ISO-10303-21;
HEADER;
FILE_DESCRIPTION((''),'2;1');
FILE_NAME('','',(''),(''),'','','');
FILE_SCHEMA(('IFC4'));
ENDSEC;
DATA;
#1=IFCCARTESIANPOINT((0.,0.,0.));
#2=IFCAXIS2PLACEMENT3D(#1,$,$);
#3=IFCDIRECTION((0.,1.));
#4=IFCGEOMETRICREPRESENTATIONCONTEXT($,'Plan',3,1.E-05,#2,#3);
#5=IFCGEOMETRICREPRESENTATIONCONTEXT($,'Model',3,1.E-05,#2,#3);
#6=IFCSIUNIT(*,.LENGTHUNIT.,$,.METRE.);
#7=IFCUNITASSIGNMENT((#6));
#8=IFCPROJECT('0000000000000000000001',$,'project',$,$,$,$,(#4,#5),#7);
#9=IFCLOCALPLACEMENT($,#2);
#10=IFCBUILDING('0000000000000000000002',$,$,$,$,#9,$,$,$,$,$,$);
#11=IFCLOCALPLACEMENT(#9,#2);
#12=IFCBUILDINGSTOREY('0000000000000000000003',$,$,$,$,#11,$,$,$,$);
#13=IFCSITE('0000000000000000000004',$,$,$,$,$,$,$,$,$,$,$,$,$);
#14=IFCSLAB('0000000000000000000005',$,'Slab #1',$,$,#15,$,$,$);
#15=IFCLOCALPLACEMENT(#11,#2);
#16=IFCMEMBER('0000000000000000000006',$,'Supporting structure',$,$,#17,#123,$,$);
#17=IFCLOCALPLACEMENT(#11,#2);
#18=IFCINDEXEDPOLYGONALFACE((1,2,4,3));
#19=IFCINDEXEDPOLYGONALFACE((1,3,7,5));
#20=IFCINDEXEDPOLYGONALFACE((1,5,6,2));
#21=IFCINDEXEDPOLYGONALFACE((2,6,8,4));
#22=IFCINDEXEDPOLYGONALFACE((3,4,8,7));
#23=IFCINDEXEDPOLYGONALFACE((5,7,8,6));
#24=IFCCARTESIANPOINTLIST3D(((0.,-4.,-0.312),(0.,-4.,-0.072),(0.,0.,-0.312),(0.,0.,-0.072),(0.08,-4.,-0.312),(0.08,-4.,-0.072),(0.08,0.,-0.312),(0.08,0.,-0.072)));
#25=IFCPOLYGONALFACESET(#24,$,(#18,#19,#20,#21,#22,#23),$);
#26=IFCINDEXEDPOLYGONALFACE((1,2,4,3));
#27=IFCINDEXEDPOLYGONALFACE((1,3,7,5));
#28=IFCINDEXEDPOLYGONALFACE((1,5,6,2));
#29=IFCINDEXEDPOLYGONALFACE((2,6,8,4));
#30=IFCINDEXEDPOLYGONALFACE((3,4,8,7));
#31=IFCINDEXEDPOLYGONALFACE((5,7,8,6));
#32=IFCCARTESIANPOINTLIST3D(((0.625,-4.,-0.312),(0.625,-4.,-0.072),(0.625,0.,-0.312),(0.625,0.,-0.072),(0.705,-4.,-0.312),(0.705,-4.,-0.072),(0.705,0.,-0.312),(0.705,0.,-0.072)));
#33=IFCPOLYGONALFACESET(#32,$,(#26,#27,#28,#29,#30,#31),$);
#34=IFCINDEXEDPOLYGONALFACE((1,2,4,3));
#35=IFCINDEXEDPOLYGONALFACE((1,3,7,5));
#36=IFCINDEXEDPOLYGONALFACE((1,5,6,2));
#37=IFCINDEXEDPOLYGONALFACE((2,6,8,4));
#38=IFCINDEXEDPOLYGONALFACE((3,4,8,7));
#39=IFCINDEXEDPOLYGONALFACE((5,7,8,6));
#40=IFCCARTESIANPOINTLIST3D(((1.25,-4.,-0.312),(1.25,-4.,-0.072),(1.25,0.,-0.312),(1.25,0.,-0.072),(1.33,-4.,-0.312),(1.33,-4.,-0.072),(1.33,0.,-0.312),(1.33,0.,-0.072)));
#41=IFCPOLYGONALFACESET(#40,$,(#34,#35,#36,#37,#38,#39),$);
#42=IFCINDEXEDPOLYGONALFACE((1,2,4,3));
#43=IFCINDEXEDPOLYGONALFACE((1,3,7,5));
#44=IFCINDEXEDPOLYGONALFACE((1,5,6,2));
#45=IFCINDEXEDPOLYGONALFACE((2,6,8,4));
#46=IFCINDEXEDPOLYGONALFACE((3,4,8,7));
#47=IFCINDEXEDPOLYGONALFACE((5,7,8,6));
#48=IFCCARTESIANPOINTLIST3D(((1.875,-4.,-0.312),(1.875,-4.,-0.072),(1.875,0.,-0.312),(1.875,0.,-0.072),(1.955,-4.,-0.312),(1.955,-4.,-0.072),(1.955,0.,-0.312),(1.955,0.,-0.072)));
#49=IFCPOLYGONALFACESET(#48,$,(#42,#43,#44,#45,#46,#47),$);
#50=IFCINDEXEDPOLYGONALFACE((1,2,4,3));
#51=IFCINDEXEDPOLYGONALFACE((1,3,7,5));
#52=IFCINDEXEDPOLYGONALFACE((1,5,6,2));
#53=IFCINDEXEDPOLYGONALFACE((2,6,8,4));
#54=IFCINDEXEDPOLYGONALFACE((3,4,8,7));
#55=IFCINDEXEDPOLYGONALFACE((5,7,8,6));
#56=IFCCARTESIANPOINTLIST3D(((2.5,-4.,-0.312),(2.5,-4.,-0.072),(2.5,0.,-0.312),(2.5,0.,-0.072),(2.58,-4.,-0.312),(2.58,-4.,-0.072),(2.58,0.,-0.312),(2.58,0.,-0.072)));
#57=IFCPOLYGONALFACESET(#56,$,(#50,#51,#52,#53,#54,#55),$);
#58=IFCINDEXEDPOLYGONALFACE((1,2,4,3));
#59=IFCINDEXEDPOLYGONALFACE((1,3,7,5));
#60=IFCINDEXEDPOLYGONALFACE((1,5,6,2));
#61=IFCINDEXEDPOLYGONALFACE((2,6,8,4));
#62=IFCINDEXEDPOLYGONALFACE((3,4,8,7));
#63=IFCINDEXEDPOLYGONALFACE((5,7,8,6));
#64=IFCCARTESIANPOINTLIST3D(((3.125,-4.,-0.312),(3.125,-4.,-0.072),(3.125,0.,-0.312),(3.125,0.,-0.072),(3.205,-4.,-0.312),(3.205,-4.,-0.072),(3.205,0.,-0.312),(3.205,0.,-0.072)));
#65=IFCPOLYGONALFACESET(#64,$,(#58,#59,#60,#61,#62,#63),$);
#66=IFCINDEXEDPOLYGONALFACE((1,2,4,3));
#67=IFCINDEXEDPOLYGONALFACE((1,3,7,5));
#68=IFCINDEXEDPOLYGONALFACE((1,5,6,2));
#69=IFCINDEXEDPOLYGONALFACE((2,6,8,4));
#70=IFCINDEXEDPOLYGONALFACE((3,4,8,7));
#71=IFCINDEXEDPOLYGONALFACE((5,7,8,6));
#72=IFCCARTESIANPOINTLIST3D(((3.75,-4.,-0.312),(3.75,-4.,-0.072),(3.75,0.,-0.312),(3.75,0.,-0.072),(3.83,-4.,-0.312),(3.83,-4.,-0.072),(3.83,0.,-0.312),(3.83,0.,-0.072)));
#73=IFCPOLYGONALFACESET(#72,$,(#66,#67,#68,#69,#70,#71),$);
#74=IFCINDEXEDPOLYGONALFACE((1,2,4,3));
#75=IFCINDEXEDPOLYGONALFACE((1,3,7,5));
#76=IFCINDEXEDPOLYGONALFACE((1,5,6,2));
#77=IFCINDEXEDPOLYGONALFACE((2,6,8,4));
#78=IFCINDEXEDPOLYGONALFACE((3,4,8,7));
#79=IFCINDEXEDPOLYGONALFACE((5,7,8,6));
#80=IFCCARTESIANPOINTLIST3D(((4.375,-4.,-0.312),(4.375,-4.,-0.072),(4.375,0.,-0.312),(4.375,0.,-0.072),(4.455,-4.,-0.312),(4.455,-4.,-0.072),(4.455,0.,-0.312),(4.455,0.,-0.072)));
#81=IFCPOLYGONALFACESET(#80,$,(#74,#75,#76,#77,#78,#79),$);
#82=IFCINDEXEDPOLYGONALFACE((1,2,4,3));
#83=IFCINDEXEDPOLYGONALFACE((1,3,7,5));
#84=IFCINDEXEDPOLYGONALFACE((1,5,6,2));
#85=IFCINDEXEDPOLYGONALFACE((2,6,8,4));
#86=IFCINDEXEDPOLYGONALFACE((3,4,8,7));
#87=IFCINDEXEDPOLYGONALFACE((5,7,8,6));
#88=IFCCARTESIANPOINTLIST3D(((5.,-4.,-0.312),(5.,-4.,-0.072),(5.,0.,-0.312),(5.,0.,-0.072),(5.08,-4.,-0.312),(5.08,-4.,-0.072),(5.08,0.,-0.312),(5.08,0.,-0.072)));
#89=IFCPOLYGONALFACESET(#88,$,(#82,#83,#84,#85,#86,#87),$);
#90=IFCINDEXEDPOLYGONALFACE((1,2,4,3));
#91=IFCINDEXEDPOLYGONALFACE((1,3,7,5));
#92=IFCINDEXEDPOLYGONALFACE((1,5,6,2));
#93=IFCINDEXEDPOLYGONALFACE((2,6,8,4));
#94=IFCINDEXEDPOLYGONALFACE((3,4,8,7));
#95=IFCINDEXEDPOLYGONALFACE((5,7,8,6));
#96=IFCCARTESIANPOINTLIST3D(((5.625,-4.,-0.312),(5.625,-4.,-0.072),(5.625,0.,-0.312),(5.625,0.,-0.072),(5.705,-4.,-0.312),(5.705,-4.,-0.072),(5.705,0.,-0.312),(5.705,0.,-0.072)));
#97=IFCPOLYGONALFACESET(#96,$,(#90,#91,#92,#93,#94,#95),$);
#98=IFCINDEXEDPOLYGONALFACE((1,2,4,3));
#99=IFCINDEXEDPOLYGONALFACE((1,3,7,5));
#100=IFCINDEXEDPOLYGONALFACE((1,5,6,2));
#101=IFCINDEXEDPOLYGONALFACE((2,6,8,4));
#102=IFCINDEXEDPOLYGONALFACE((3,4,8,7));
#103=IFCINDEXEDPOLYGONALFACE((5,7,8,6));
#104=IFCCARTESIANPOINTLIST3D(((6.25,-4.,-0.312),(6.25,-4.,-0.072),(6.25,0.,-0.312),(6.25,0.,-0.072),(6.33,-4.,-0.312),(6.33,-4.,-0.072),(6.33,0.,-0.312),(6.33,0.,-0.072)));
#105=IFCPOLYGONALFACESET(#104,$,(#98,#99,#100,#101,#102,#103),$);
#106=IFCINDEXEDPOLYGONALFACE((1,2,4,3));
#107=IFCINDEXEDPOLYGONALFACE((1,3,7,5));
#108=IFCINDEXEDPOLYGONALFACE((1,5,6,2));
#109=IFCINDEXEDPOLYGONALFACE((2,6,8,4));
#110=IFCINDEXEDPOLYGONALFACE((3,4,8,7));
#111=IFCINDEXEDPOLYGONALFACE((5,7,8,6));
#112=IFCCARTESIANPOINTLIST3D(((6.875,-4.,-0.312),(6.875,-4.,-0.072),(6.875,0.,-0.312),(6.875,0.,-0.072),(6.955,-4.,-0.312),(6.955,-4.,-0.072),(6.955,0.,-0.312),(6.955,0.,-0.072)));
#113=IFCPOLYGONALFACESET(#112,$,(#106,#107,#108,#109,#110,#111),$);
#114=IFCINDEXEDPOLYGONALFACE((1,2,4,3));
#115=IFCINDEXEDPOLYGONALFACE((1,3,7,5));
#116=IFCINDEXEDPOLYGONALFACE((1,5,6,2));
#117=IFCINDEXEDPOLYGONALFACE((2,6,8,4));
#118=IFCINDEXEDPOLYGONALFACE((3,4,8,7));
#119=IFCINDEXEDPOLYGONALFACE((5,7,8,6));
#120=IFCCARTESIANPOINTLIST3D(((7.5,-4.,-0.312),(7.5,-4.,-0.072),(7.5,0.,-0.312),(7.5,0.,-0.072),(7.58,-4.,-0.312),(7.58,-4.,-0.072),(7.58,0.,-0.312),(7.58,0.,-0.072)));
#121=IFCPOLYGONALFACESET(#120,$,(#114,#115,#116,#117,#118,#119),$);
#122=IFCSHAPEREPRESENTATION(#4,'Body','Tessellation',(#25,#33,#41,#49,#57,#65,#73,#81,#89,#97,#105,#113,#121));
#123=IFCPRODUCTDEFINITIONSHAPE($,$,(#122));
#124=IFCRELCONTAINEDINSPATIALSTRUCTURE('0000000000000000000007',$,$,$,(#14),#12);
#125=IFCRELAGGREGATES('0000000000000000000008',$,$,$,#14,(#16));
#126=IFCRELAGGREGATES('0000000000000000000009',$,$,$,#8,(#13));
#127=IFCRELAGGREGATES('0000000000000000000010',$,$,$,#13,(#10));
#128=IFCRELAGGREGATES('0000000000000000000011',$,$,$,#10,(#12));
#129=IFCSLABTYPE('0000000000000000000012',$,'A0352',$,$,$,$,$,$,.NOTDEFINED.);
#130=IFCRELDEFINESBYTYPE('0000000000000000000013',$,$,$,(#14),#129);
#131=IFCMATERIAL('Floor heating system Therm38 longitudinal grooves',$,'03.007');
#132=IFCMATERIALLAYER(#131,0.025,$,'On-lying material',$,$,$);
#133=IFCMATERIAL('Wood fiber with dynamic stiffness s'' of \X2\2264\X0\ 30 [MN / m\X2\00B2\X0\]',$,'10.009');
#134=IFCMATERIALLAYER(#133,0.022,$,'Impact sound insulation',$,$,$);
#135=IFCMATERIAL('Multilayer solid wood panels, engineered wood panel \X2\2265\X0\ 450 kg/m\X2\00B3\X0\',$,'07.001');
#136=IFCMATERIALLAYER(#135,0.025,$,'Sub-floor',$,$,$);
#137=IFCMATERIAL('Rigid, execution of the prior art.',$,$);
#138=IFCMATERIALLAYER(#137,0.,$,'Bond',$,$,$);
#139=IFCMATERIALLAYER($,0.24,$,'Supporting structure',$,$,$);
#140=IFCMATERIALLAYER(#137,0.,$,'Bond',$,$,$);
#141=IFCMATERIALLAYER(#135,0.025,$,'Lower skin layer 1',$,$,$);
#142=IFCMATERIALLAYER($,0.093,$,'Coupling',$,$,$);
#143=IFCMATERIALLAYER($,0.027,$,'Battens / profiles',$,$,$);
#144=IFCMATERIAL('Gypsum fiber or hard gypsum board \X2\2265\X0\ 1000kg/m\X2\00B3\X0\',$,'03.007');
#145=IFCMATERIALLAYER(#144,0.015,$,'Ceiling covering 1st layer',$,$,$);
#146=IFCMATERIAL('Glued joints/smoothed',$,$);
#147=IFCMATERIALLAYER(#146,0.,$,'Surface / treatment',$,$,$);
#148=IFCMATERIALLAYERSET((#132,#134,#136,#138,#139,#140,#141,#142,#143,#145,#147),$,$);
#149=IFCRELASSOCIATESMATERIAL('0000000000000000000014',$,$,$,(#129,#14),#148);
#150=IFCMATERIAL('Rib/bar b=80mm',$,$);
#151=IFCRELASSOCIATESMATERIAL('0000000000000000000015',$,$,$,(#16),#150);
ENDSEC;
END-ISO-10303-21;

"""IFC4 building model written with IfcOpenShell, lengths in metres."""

from ifc_helpers import new_model, si_unit, direction, frame, frame_2d, origin, place, context, project, spatial, rectangle, extrude, material, layer, layer_set, type_object, element, aggregate, save


model = new_model("IFC4")

# Units and contexts
plan_context = context("Plan", 3, precision=1e-05, world=origin(), true_north=direction((0.0, 1.0)))
model_context = context("Model", 3, precision=1e-05, world=origin(), true_north=direction((0.0, 1.0)))
ifc_project = project(units=[si_unit("LENGTHUNIT", "METRE")], contexts=[plan_context, model_context])

# Site, building, storey
site = spatial("IfcSite", under=ifc_project)
building_placement = place(None, origin())
building = spatial("IfcBuilding", under=site, at=building_placement)
storey_placement = place(building_placement, origin())
storey = spatial("IfcBuildingStorey", under=building, at=storey_placement)

# Slab, member
ifc_material_1 = material(Name="Floor heating system Therm38 longitudinal grooves", Category="03.007")
ifc_layer_1 = layer(ifc_material_1, 0.025, Name="On-lying material")
ifc_material_2 = material(Name="Wood fiber with dynamic stiffness s' of ≤ 30 [MN / m²]", Category="10.009")
ifc_layer_2 = layer(ifc_material_2, 0.022, Name="Impact sound insulation")
ifc_material_3 = material(Name="Multilayer solid wood panels, engineered wood panel ≥ 450 kg/m³", Category="07.001")
ifc_layer_3 = layer(ifc_material_3, 0.025, Name="Sub-floor")
ifc_material_4 = material(Name="Rigid, execution of the prior art.")
ifc_layer_4 = layer(ifc_material_4, 0.0, Name="Bond")
ifc_layer_5 = layer(None, 0.24, Name="Supporting structure")
ifc_layer_6 = layer(ifc_material_4, 0.0, Name="Bond")
ifc_layer_7 = layer(ifc_material_3, 0.025, Name="Lower skin layer 1")
ifc_layer_8 = layer(None, 0.093, Name="Coupling")
ifc_layer_9 = layer(None, 0.027, Name="Battens / profiles")
ifc_material_5 = material(Name="Gypsum fiber or hard gypsum board ≥ 1000kg/m³", Category="03.007")
ifc_layer_10 = layer(ifc_material_5, 0.015, Name="Ceiling covering 1st layer")
ifc_material_6 = material(Name="Glued joints/smoothed")
ifc_layer_11 = layer(ifc_material_6, 0.0, Name="Surface / treatment")
ifc_layer_set = layer_set([ifc_layer_1, ifc_layer_2, ifc_layer_3, ifc_layer_4, ifc_layer_5, ifc_layer_6, ifc_layer_7, ifc_layer_8, ifc_layer_9, ifc_layer_10, ifc_layer_11])
slab_type = type_object("IfcSlabType", Name="A0352", PredefinedType="NOTDEFINED", material=ifc_layer_set)
slab_placement = place(None, frame((0.0, 0.0, 0.0), z_axis=(0.0, 0.0, -1.0), x_axis=(1.0, 0.0, 0.0)))
slab = element("IfcSlab", 1, at=slab_placement, inside=storey, type_object=slab_type, material=ifc_layer_set, Name="Slab #1")
ifc_material_7 = material(Name="Rib/bar b=80mm")
member_1_placement = place(slab_placement, origin())
member_1 = element("IfcMember", 2, at=member_1_placement, material=ifc_material_7, Name="Supporting structure", context=plan_context, shape_type="SweptSolid", body=[
    extrude(rectangle(XDim=0.08, YDim=0.24, at=frame_2d((0.04, 0.12), x_axis=(1.0, 0.0))), frame((0.0, 4.0, 0.072), z_axis=(0.0, -1.0, 0.0), x_axis=(1.0, 0.0, 0.0)), (0.0, 0.0, 1.0), 4.0),
    extrude(rectangle(XDim=0.08, YDim=0.24, at=frame_2d((0.04, 0.12), x_axis=(1.0, 0.0))), frame((0.625, 4.0, 0.072), z_axis=(0.0, -1.0, 0.0), x_axis=(1.0, 0.0, 0.0)), (0.0, 0.0, 1.0), 4.0),
    extrude(rectangle(XDim=0.08, YDim=0.24, at=frame_2d((0.04, 0.12), x_axis=(1.0, 0.0))), frame((1.25, 4.0, 0.072), z_axis=(0.0, -1.0, 0.0), x_axis=(1.0, 0.0, 0.0)), (0.0, 0.0, 1.0), 4.0),
    extrude(rectangle(XDim=0.08, YDim=0.24, at=frame_2d((0.04, 0.12), x_axis=(1.0, 0.0))), frame((1.875, 4.0, 0.072), z_axis=(0.0, -1.0, 0.0), x_axis=(1.0, 0.0, 0.0)), (0.0, 0.0, 1.0), 4.0),
    extrude(rectangle(XDim=0.08, YDim=0.24, at=frame_2d((0.04, 0.12), x_axis=(1.0, 0.0))), frame((2.5, 4.0, 0.072), z_axis=(0.0, -1.0, 0.0), x_axis=(1.0, 0.0, 0.0)), (0.0, 0.0, 1.0), 4.0),
    extrude(rectangle(XDim=0.08, YDim=0.24, at=frame_2d((0.04, 0.12), x_axis=(1.0, 0.0))), frame((3.125, 4.0, 0.072), z_axis=(0.0, -1.0, 0.0), x_axis=(1.0, 0.0, 0.0)), (0.0, 0.0, 1.0), 4.0),
    extrude(rectangle(XDim=0.08, YDim=0.24, at=frame_2d((0.04, 0.12), x_axis=(1.0, 0.0))), frame((3.75, 4.0, 0.072), z_axis=(0.0, -1.0, 0.0), x_axis=(1.0, 0.0, 0.0)), (0.0, 0.0, 1.0), 4.0),
    extrude(rectangle(XDim=0.08, YDim=0.24, at=frame_2d((0.04, 0.12), x_axis=(1.0, 0.0))), frame((4.375, 4.0, 0.072), z_axis=(0.0, -1.0, 0.0), x_axis=(1.0, 0.0, 0.0)), (0.0, 0.0, 1.0), 4.0),
    extrude(rectangle(XDim=0.08, YDim=0.24, at=frame_2d((0.04, 0.12), x_axis=(1.0, 0.0))), frame((5.0, 4.0, 0.072), z_axis=(0.0, -1.0, 0.0), x_axis=(1.0, 0.0, 0.0)), (0.0, 0.0, 1.0), 4.0),
    extrude(rectangle(XDim=0.08, YDim=0.24, at=frame_2d((0.04, 0.12), x_axis=(1.0, 0.0))), frame((5.625, 4.0, 0.072), z_axis=(0.0, -1.0, 0.0), x_axis=(1.0, 0.0, 0.0)), (0.0, 0.0, 1.0), 4.0),
    extrude(rectangle(XDim=0.08, YDim=0.24, at=frame_2d((0.04, 0.12), x_axis=(1.0, 0.0))), frame((6.25, 4.0, 0.072), z_axis=(0.0, -1.0, 0.0), x_axis=(1.0, 0.0, 0.0)), (0.0, 0.0, 1.0), 4.0),
    extrude(rectangle(XDim=0.08, YDim=0.24, at=frame_2d((0.04, 0.12), x_axis=(1.0, 0.0))), frame((6.875, 4.0, 0.072), z_axis=(0.0, -1.0, 0.0), x_axis=(1.0, 0.0, 0.0)), (0.0, 0.0, 1.0), 4.0),
    extrude(rectangle(XDim=0.08, YDim=0.24, at=frame_2d((0.04, 0.12), x_axis=(1.0, 0.0))), frame((7.5, 4.0, 0.072), z_axis=(0.0, -1.0, 0.0), x_axis=(1.0, 0.0, 0.0)), (0.0, 0.0, 1.0), 4.0),
])
aggregate(slab, [member_1])

save(model, "model.ifc")
